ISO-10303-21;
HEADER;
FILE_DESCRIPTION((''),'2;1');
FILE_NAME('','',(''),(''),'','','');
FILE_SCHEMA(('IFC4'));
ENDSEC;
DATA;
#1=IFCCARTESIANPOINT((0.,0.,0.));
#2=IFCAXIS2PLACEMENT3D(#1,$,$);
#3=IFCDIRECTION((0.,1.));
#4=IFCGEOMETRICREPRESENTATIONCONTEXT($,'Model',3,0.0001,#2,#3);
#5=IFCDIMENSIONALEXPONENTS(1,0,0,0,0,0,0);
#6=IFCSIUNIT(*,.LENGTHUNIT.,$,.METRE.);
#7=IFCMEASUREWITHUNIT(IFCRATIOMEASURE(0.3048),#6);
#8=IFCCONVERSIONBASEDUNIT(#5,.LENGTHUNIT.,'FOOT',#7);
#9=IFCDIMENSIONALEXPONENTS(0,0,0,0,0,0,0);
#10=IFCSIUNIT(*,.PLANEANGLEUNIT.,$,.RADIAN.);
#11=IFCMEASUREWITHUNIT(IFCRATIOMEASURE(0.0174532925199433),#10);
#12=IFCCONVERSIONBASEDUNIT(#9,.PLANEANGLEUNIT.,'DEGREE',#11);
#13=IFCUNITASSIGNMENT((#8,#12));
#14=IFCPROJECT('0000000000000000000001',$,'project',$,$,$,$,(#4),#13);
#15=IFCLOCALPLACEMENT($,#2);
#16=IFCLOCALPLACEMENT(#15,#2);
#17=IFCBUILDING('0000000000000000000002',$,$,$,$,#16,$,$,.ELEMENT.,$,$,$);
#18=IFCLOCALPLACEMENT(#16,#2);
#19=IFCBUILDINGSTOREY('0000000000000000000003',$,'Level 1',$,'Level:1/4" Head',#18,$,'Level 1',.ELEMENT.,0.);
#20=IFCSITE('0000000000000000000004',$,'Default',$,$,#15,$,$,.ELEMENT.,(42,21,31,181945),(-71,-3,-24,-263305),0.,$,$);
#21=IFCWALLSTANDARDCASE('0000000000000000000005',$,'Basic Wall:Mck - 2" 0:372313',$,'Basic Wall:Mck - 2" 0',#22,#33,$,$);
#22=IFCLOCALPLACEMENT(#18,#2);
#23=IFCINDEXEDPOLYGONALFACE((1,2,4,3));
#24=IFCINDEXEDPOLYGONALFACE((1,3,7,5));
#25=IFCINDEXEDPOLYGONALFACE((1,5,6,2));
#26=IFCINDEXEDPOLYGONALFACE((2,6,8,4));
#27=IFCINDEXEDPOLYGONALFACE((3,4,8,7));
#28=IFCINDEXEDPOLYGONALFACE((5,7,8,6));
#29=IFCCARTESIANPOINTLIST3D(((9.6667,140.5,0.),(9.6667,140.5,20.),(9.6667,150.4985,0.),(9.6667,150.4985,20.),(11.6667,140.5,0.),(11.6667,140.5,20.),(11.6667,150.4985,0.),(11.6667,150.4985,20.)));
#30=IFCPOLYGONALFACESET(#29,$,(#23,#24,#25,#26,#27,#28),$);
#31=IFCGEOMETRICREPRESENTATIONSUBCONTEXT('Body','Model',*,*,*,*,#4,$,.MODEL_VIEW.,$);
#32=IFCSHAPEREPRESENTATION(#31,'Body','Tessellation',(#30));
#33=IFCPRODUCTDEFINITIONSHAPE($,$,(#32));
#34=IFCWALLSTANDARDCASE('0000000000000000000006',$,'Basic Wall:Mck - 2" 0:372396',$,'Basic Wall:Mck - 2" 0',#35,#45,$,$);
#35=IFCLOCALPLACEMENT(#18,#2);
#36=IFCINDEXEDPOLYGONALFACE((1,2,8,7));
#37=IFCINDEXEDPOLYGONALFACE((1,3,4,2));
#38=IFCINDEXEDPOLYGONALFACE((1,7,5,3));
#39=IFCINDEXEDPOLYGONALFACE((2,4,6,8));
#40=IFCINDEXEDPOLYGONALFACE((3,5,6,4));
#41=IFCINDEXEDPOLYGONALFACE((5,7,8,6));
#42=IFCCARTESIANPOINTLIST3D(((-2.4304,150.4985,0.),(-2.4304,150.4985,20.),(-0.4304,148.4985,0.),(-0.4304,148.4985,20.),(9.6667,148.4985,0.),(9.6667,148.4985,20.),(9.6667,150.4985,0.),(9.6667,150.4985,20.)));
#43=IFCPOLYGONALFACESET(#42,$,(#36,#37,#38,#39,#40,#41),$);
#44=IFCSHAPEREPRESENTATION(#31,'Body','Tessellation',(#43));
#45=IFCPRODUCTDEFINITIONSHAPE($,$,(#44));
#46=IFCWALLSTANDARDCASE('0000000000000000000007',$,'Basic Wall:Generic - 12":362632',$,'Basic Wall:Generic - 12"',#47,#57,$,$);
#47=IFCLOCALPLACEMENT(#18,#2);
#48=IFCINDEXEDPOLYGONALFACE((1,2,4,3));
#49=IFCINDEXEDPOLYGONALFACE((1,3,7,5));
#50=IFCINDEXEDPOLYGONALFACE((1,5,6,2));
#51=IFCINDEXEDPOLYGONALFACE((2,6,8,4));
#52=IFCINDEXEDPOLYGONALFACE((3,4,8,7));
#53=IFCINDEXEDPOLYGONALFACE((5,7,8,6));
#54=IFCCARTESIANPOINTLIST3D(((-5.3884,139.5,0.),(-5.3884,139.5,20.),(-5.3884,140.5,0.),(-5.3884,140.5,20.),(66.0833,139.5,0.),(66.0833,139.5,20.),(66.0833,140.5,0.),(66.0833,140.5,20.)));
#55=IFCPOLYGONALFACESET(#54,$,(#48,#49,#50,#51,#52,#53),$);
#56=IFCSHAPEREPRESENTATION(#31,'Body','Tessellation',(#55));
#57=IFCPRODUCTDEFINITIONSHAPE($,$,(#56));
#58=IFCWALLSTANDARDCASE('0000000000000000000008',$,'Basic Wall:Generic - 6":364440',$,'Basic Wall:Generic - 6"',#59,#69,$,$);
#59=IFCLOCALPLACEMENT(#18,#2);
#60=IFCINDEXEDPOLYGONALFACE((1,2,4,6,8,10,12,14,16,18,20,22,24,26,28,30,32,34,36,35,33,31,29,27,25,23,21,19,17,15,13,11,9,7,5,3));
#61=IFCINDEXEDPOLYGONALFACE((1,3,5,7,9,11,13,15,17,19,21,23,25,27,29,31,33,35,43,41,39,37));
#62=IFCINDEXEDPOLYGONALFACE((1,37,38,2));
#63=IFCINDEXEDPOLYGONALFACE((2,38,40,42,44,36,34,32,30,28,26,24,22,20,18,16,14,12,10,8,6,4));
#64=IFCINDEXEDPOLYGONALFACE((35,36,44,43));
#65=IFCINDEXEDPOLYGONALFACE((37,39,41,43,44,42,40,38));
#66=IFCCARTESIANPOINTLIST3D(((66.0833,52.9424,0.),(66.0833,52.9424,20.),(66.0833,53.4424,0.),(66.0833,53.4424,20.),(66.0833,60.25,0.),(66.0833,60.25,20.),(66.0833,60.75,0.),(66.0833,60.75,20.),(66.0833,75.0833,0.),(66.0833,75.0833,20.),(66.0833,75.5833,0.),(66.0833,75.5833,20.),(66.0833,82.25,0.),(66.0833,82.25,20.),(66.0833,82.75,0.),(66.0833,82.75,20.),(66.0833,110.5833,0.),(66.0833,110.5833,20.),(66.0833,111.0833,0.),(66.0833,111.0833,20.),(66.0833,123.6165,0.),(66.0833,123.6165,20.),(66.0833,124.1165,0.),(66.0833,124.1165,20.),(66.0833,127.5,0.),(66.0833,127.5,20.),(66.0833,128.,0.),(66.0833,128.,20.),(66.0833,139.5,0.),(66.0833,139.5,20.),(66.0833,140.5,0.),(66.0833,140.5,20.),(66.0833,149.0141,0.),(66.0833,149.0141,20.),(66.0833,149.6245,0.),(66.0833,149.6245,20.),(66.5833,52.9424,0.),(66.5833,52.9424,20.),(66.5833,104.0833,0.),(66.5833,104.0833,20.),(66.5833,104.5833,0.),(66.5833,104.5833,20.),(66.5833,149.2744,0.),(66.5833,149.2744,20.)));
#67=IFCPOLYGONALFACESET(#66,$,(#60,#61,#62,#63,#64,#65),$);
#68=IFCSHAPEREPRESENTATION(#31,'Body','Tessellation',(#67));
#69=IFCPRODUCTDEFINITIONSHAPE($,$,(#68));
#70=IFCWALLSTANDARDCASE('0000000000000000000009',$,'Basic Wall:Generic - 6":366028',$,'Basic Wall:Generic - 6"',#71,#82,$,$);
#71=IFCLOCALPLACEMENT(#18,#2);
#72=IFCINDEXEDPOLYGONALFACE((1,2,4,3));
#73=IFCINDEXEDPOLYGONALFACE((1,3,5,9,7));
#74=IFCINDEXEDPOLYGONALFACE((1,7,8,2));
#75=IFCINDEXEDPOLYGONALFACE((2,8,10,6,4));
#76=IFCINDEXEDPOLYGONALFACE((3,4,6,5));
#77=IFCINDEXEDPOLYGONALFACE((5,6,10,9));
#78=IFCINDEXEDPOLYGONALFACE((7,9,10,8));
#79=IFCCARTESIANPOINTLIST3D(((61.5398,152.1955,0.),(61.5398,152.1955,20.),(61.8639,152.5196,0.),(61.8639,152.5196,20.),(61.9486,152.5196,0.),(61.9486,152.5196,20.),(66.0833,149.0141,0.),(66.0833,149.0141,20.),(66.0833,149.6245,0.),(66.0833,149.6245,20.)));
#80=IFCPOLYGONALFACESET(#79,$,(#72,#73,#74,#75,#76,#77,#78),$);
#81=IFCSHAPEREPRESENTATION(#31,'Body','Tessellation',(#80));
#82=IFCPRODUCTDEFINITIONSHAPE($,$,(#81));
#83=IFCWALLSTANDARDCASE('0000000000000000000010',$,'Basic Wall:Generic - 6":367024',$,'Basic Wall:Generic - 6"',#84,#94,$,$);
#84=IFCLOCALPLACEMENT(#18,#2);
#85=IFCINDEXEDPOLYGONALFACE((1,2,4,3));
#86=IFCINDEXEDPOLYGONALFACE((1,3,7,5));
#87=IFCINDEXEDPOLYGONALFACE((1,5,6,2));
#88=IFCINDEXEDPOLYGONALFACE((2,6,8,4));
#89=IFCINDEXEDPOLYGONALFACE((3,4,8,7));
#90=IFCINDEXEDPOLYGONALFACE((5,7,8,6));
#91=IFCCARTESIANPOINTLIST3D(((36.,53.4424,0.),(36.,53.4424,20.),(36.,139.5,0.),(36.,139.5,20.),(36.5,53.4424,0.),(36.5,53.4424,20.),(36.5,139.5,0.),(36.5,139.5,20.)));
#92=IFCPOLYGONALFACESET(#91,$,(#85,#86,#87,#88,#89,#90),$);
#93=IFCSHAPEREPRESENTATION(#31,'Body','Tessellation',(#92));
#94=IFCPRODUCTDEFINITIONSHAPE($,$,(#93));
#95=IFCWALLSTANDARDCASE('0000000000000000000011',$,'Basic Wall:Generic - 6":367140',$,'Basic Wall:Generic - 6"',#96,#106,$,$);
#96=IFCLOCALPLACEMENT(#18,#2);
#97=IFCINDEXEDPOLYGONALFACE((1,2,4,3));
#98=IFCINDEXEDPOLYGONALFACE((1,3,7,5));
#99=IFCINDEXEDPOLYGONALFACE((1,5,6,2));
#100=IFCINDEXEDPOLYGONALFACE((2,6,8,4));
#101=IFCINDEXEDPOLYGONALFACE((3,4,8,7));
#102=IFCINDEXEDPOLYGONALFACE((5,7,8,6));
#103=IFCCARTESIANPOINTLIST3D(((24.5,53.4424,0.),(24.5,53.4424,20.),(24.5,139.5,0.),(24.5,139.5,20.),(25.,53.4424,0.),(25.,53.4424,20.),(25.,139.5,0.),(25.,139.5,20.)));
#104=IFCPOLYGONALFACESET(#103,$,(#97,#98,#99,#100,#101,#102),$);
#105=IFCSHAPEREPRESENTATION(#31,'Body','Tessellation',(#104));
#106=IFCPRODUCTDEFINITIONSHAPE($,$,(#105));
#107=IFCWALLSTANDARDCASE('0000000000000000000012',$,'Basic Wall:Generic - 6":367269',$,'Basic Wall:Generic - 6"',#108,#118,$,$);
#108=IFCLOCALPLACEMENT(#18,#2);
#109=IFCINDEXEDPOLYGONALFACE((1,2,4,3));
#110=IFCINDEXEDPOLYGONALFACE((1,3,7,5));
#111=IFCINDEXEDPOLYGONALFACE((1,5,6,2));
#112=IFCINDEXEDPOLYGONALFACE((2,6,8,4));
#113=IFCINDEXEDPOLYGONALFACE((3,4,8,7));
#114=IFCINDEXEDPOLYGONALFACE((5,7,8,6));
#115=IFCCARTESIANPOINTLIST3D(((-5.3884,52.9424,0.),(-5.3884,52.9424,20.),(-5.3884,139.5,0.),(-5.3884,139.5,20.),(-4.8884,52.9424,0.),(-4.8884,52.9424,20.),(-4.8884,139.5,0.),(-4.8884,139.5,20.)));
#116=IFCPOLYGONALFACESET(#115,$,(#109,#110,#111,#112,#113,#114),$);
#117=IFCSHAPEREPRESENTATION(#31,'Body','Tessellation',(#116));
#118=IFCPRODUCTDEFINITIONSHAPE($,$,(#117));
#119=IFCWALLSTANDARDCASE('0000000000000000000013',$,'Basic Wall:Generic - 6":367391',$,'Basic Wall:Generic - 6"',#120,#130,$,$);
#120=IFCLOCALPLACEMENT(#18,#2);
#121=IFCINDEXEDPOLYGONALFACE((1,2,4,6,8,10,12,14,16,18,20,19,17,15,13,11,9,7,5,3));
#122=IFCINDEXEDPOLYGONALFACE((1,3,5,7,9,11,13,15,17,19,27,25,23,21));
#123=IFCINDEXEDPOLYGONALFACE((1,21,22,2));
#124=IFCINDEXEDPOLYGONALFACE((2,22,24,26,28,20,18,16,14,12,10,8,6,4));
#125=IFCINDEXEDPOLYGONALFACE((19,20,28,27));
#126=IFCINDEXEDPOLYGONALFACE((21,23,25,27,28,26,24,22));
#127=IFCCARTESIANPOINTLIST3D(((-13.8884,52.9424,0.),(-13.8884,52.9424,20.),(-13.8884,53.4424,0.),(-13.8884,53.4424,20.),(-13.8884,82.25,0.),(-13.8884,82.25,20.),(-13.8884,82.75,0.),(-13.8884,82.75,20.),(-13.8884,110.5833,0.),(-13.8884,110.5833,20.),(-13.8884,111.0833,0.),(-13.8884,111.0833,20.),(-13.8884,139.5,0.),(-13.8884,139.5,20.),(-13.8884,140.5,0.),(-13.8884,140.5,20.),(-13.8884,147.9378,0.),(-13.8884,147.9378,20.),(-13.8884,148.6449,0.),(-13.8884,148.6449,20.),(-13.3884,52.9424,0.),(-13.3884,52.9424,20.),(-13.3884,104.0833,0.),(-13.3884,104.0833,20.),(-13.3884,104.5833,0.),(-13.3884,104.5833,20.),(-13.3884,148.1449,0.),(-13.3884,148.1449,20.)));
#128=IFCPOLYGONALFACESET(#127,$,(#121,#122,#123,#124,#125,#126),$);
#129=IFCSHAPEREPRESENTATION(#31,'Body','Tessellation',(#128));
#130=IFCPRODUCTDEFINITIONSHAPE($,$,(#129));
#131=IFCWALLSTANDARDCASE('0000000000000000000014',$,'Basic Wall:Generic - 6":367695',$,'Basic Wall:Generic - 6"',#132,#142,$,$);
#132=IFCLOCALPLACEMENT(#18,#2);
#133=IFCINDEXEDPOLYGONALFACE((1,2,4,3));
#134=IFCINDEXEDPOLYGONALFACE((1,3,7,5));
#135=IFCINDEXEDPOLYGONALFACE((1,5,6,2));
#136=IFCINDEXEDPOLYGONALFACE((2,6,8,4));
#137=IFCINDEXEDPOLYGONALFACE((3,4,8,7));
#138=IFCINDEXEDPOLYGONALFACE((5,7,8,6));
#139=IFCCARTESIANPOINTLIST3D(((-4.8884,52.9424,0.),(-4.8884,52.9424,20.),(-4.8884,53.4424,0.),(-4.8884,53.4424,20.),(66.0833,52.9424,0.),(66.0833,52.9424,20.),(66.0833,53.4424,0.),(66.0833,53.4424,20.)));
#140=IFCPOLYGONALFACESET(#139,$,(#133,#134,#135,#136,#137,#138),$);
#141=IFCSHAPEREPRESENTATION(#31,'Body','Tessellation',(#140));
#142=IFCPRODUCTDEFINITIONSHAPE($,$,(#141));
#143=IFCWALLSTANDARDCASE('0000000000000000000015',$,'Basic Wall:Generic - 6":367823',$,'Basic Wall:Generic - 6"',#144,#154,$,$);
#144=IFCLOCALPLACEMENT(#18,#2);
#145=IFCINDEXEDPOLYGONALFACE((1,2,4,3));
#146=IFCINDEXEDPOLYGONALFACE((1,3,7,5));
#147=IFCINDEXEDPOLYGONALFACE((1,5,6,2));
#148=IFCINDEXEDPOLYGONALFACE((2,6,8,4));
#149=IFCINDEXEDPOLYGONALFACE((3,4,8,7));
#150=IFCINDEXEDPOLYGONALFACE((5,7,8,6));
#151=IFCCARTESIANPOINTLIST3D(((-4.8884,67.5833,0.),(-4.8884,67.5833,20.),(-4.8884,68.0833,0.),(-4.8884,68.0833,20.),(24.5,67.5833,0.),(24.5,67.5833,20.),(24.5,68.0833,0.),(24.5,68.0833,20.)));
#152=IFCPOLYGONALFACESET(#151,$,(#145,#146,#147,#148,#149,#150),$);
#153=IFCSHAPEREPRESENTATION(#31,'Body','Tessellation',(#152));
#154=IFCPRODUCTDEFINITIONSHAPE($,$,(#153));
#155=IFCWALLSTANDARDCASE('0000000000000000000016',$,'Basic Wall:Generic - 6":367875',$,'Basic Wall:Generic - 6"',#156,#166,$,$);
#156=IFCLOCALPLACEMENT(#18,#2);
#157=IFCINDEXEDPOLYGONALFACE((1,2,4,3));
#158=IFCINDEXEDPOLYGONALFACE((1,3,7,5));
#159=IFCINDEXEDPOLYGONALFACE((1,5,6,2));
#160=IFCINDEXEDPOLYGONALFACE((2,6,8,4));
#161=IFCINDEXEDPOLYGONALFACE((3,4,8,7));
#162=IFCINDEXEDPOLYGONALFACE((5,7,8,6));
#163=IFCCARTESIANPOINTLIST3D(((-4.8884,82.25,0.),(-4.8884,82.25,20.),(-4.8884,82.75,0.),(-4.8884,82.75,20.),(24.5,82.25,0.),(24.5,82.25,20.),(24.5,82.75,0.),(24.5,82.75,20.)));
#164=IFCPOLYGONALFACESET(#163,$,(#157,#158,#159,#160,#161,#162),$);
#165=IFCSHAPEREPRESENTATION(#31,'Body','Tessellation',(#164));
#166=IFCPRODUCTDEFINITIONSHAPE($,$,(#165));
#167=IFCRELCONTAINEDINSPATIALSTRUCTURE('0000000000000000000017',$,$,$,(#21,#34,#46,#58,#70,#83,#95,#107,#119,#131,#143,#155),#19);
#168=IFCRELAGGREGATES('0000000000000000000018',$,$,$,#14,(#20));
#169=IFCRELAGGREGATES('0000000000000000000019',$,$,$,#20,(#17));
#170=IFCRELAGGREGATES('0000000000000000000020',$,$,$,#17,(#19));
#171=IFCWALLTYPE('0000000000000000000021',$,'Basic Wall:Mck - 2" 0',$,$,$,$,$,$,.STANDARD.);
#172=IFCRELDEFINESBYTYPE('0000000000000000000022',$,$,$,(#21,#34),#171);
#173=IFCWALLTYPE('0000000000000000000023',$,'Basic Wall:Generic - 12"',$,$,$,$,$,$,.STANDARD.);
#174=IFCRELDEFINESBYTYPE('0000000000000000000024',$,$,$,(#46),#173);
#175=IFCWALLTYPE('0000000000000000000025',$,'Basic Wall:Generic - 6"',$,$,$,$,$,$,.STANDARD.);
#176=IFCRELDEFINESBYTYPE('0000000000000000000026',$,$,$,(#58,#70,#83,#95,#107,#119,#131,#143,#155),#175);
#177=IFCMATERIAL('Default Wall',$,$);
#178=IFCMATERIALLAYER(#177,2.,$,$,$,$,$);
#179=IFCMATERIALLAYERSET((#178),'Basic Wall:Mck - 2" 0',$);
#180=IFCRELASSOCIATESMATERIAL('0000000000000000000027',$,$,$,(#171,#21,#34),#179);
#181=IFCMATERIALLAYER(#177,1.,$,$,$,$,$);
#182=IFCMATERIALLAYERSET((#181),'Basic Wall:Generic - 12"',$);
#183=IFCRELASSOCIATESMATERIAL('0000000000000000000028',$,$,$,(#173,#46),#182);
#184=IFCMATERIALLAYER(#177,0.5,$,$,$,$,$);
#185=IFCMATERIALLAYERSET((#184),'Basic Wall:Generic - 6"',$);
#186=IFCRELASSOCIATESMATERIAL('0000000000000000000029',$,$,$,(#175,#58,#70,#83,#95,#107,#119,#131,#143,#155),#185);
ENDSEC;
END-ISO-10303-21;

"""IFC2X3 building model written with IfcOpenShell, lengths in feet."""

from ifc_helpers import new_model, entity, si_unit, converted_unit, direction, frame, frame_2d, origin, place, context, subcontext, project, spatial, polyline, rectangle, outline, extrude, material, layer, layer_set, layer_usage, type_object, element, save


model = new_model("IFC2X3")

# Units and contexts
model_context = context("Model", 3, precision=0.0001, world=origin(), true_north=direction((0.0, 1.0)))
body_context = subcontext(model_context, "Body", "Model", "MODEL_VIEW")
ifc_project = project(units=[converted_unit("LENGTHUNIT", "FOOT", entity("IfcRatioMeasure", 0.3048), si_unit("LENGTHUNIT", "METRE"), dimensions=[1, 0, 0, 0, 0, 0, 0]), converted_unit("PLANEANGLEUNIT", "DEGREE", entity("IfcRatioMeasure", 0.0174532925199433), si_unit("PLANEANGLEUNIT", "RADIAN"), dimensions=[0, 0, 0, 0, 0, 0, 0])], contexts=[model_context])

# Site, building, storey
site_placement = place(None, origin())
site = spatial("IfcSite", under=ifc_project, at=site_placement, Name="Default", CompositionType="ELEMENT", RefLatitude=(42, 21, 31, 181945), RefLongitude=(-71, -3, -24, -263305), RefElevation=0.0)
building_placement = place(site_placement, origin())
building = spatial("IfcBuilding", under=site, at=building_placement, CompositionType="ELEMENT")
storey_placement = place(building_placement, origin())
storey = spatial("IfcBuildingStorey", under=building, at=storey_placement, Name="Level 1", ObjectType="Level:1/4\" Head", LongName="Level 1", CompositionType="ELEMENT", Elevation=0.0)

# Walls
ifc_material = material(Name="Default Wall")
ifc_layer_1 = layer(ifc_material, 2.0)
ifc_layer_set_1 = layer_set([ifc_layer_1], Name="Basic Wall:Mck - 2\" 0")
ifc_layer_usage_1 = layer_usage(ifc_layer_set_1, "AXIS2", "NEGATIVE", 1.0)
wall_type_1 = type_object("IfcWallType", Name="Basic Wall:Mck - 2\" 0", PredefinedType="STANDARD", material=ifc_layer_set_1)
wall_1_placement = place(storey_placement, frame((10.6667, 140.5, 0.0), z_axis=(0.0, 0.0, 1.0), x_axis=(0.0, 1.0, 0.0)))
element("IfcWallStandardCase", 1, at=wall_1_placement, inside=storey, type_object=wall_type_1, material=ifc_layer_usage_1, Name="Basic Wall:Mck - 2\" 0:372313", ObjectType="Basic Wall:Mck - 2\" 0", context=body_context, shape_type="SweptSolid", body=[
    extrude(rectangle(XDim=9.9985, YDim=2.0, at=frame_2d((4.9992, 0.0), x_axis=(-1.0, 0.0))), origin(), (0.0, 0.0, 1.0), 20.0),
])
ifc_layer_usage_2 = layer_usage(ifc_layer_set_1, "AXIS2", "NEGATIVE", 1.0)
wall_2_placement = place(storey_placement, frame((9.6667, 149.4985, 0.0), z_axis=(0.0, 0.0, 1.0), x_axis=(-1.0, 0.0, 0.0)))
element("IfcWallStandardCase", 2, at=wall_2_placement, inside=storey, type_object=wall_type_1, material=ifc_layer_usage_2, Name="Basic Wall:Mck - 2\" 0:372396", ObjectType="Basic Wall:Mck - 2\" 0", context=body_context, shape_type="SweptSolid", body=[
    extrude(outline(polyline([(12.097, -1.0), (10.097, 1.0), (0.0, 1.0), (0.0, -1.0), (12.097, -1.0)])), origin(), (0.0, 0.0, 1.0), 20.0),
])
ifc_layer_2 = layer(ifc_material, 1.0)
ifc_layer_set_2 = layer_set([ifc_layer_2], Name="Basic Wall:Generic - 12\"")
ifc_layer_usage_3 = layer_usage(ifc_layer_set_2, "AXIS2", "NEGATIVE", 0.5)
wall_type_2 = type_object("IfcWallType", Name="Basic Wall:Generic - 12\"", PredefinedType="STANDARD", material=ifc_layer_set_2)
wall_3_placement = place(storey_placement, frame((-5.3884, 140.0, 0.0)))
element("IfcWallStandardCase", 3, at=wall_3_placement, inside=storey, type_object=wall_type_2, material=ifc_layer_usage_3, Name="Basic Wall:Generic - 12\":362632", ObjectType="Basic Wall:Generic - 12\"", context=body_context, shape_type="SweptSolid", body=[
    extrude(rectangle(XDim=71.4718, YDim=1.0, at=frame_2d((35.7359, 0.0), x_axis=(-1.0, 0.0))), origin(), (0.0, 0.0, 1.0), 20.0),
])
ifc_layer_3 = layer(ifc_material, 0.5)
ifc_layer_set_3 = layer_set([ifc_layer_3], Name="Basic Wall:Generic - 6\"")
ifc_layer_usage_4 = layer_usage(ifc_layer_set_3, "AXIS2", "NEGATIVE", 0.25)
wall_type_3 = type_object("IfcWallType", Name="Basic Wall:Generic - 6\"", PredefinedType="STANDARD", material=ifc_layer_set_3)
wall_4_placement = place(storey_placement, frame((66.3333, 149.6245, 0.0), z_axis=(0.0, 0.0, 1.0), x_axis=(0.0, -1.0, 0.0)))
element("IfcWallStandardCase", 4, at=wall_4_placement, inside=storey, type_object=wall_type_3, material=ifc_layer_usage_4, Name="Basic Wall:Generic - 6\":364440", ObjectType="Basic Wall:Generic - 6\"", context=body_context, shape_type="SweptSolid", body=[
    extrude(outline(polyline([(96.6821, -0.25), (96.6821, 0.25), (45.5411, 0.25), (45.0411, 0.25), (0.3501, 0.25), (0.0, -0.25), (0.6104, -0.25), (9.1245, -0.25), (10.1245, -0.25), (21.6245, -0.25), (22.1245, -0.25), (25.5079, -0.25), (26.0079, -0.25), (38.5411, -0.25), (39.0411, -0.25), (66.8745, -0.25), (67.3745, -0.25), (74.0411, -0.25), (74.5411, -0.25), (88.8745, -0.25), (89.3745, -0.25), (96.1821, -0.25), (96.6821, -0.25)])), origin(), (0.0, 0.0, 1.0), 20.0),
])
ifc_layer_usage_5 = layer_usage(ifc_layer_set_3, "AXIS2", "NEGATIVE", 0.25)
wall_5_placement = place(storey_placement, frame((61.6832, 152.4003, 0.0), z_axis=(0.0, 0.0, 1.0), x_axis=(0.819152, -0.573576, 0.0)))
element("IfcWallStandardCase", 5, at=wall_5_placement, inside=storey, type_object=wall_type_3, material=ifc_layer_usage_5, Name="Basic Wall:Generic - 6\":366028", ObjectType="Basic Wall:Generic - 6\"", context=body_context, shape_type="SweptSolid", body=[
    extrude(outline(polyline([(5.5467, -0.25), (5.1966, 0.25), (0.149, 0.25), (0.0796, 0.2014), (0.0, -0.25), (5.5467, -0.25)])), origin(), (0.0, 0.0, 1.0), 20.0),
])
ifc_layer_usage_6 = layer_usage(ifc_layer_set_3, "AXIS2", "NEGATIVE", 0.25)
wall_6_placement = place(storey_placement, frame((36.25, 139.5, 0.0), z_axis=(0.0, 0.0, 1.0), x_axis=(0.0, -1.0, 0.0)))
element("IfcWallStandardCase", 6, at=wall_6_placement, inside=storey, type_object=wall_type_3, material=ifc_layer_usage_6, Name="Basic Wall:Generic - 6\":367024", ObjectType="Basic Wall:Generic - 6\"", context=body_context, shape_type="SweptSolid", body=[
    extrude(rectangle(XDim=86.0576, YDim=0.5, at=frame_2d((43.0288, 0.0), x_axis=(-1.0, 0.0))), origin(), (0.0, 0.0, 1.0), 20.0),
])
ifc_layer_usage_7 = layer_usage(ifc_layer_set_3, "AXIS2", "NEGATIVE", 0.25)
wall_7_placement = place(storey_placement, frame((24.75, 139.5, 0.0), z_axis=(0.0, 0.0, 1.0), x_axis=(0.0, -1.0, 0.0)))
element("IfcWallStandardCase", 7, at=wall_7_placement, inside=storey, type_object=wall_type_3, material=ifc_layer_usage_7, Name="Basic Wall:Generic - 6\":367140", ObjectType="Basic Wall:Generic - 6\"", context=body_context, shape_type="SweptSolid", body=[
    extrude(rectangle(XDim=86.0576, YDim=0.5, at=frame_2d((43.0288, 0.0), x_axis=(-1.0, 0.0))), origin(), (0.0, 0.0, 1.0), 20.0),
])
ifc_layer_usage_8 = layer_usage(ifc_layer_set_3, "AXIS2", "NEGATIVE", 0.25)
wall_8_placement = place(storey_placement, frame((-5.1384, 139.5, 0.0), z_axis=(0.0, 0.0, 1.0), x_axis=(0.0, -1.0, 0.0)))
element("IfcWallStandardCase", 8, at=wall_8_placement, inside=storey, type_object=wall_type_3, material=ifc_layer_usage_8, Name="Basic Wall:Generic - 6\":367269", ObjectType="Basic Wall:Generic - 6\"", context=body_context, shape_type="SweptSolid", body=[
    extrude(rectangle(XDim=86.5576, YDim=0.5, at=frame_2d((43.2788, 0.0), x_axis=(-1.0, 0.0))), origin(), (0.0, 0.0, 1.0), 20.0),
])
ifc_layer_usage_9 = layer_usage(ifc_layer_set_3, "AXIS2", "NEGATIVE", 0.25)
wall_9_placement = place(storey_placement, frame((-13.6384, 148.6449, 0.0), z_axis=(0.0, 0.0, 1.0), x_axis=(0.0, -1.0, 0.0)))
element("IfcWallStandardCase", 9, at=wall_9_placement, inside=storey, type_object=wall_type_3, material=ifc_layer_usage_9, Name="Basic Wall:Generic - 6\":367391", ObjectType="Basic Wall:Generic - 6\"", context=body_context, shape_type="SweptSolid", body=[
    extrude(outline(polyline([(95.7026, -0.25), (95.7026, 0.25), (44.5616, 0.25), (44.0616, 0.25), (0.5, 0.25), (0.0, -0.25), (0.7071, -0.25), (8.1449, -0.25), (9.1449, -0.25), (37.5616, -0.25), (38.0616, -0.25), (65.8949, -0.25), (66.3949, -0.25), (95.2026, -0.25), (95.7026, -0.25)])), origin(), (0.0, 0.0, 1.0), 20.0),
])
ifc_layer_usage_10 = layer_usage(ifc_layer_set_3, "AXIS2", "NEGATIVE", 0.25)
wall_10_placement = place(storey_placement, frame((66.0833, 53.1924, 0.0), z_axis=(0.0, 0.0, 1.0), x_axis=(-1.0, 0.0, 0.0)))
element("IfcWallStandardCase", 10, at=wall_10_placement, inside=storey, type_object=wall_type_3, material=ifc_layer_usage_10, Name="Basic Wall:Generic - 6\":367695", ObjectType="Basic Wall:Generic - 6\"", context=body_context, shape_type="SweptSolid", body=[
    extrude(rectangle(XDim=70.9718, YDim=0.5, at=frame_2d((35.4859, 0.0), x_axis=(-1.0, 0.0))), origin(), (0.0, 0.0, 1.0), 20.0),
])
ifc_layer_usage_11 = layer_usage(ifc_layer_set_3, "AXIS2", "NEGATIVE", 0.25)
wall_11_placement = place(storey_placement, frame((24.5, 67.8333, 0.0), z_axis=(0.0, 0.0, 1.0), x_axis=(-1.0, 0.0, 0.0)))
element("IfcWallStandardCase", 11, at=wall_11_placement, inside=storey, type_object=wall_type_3, material=ifc_layer_usage_11, Name="Basic Wall:Generic - 6\":367823", ObjectType="Basic Wall:Generic - 6\"", context=body_context, shape_type="SweptSolid", body=[
    extrude(rectangle(XDim=29.3884, YDim=0.5, at=frame_2d((14.6942, 0.0), x_axis=(-1.0, 0.0))), origin(), (0.0, 0.0, 1.0), 20.0),
])
ifc_layer_usage_12 = layer_usage(ifc_layer_set_3, "AXIS2", "NEGATIVE", 0.25)
wall_12_placement = place(storey_placement, frame((24.5, 82.5, 0.0), z_axis=(0.0, 0.0, 1.0), x_axis=(-1.0, 0.0, 0.0)))
element("IfcWallStandardCase", 12, at=wall_12_placement, inside=storey, type_object=wall_type_3, material=ifc_layer_usage_12, Name="Basic Wall:Generic - 6\":367875", ObjectType="Basic Wall:Generic - 6\"", context=body_context, shape_type="SweptSolid", body=[
    extrude(rectangle(XDim=29.3884, YDim=0.5, at=frame_2d((14.6942, 0.0), x_axis=(-1.0, 0.0))), origin(), (0.0, 0.0, 1.0), 20.0),
])

save(model, "model.ifc")
